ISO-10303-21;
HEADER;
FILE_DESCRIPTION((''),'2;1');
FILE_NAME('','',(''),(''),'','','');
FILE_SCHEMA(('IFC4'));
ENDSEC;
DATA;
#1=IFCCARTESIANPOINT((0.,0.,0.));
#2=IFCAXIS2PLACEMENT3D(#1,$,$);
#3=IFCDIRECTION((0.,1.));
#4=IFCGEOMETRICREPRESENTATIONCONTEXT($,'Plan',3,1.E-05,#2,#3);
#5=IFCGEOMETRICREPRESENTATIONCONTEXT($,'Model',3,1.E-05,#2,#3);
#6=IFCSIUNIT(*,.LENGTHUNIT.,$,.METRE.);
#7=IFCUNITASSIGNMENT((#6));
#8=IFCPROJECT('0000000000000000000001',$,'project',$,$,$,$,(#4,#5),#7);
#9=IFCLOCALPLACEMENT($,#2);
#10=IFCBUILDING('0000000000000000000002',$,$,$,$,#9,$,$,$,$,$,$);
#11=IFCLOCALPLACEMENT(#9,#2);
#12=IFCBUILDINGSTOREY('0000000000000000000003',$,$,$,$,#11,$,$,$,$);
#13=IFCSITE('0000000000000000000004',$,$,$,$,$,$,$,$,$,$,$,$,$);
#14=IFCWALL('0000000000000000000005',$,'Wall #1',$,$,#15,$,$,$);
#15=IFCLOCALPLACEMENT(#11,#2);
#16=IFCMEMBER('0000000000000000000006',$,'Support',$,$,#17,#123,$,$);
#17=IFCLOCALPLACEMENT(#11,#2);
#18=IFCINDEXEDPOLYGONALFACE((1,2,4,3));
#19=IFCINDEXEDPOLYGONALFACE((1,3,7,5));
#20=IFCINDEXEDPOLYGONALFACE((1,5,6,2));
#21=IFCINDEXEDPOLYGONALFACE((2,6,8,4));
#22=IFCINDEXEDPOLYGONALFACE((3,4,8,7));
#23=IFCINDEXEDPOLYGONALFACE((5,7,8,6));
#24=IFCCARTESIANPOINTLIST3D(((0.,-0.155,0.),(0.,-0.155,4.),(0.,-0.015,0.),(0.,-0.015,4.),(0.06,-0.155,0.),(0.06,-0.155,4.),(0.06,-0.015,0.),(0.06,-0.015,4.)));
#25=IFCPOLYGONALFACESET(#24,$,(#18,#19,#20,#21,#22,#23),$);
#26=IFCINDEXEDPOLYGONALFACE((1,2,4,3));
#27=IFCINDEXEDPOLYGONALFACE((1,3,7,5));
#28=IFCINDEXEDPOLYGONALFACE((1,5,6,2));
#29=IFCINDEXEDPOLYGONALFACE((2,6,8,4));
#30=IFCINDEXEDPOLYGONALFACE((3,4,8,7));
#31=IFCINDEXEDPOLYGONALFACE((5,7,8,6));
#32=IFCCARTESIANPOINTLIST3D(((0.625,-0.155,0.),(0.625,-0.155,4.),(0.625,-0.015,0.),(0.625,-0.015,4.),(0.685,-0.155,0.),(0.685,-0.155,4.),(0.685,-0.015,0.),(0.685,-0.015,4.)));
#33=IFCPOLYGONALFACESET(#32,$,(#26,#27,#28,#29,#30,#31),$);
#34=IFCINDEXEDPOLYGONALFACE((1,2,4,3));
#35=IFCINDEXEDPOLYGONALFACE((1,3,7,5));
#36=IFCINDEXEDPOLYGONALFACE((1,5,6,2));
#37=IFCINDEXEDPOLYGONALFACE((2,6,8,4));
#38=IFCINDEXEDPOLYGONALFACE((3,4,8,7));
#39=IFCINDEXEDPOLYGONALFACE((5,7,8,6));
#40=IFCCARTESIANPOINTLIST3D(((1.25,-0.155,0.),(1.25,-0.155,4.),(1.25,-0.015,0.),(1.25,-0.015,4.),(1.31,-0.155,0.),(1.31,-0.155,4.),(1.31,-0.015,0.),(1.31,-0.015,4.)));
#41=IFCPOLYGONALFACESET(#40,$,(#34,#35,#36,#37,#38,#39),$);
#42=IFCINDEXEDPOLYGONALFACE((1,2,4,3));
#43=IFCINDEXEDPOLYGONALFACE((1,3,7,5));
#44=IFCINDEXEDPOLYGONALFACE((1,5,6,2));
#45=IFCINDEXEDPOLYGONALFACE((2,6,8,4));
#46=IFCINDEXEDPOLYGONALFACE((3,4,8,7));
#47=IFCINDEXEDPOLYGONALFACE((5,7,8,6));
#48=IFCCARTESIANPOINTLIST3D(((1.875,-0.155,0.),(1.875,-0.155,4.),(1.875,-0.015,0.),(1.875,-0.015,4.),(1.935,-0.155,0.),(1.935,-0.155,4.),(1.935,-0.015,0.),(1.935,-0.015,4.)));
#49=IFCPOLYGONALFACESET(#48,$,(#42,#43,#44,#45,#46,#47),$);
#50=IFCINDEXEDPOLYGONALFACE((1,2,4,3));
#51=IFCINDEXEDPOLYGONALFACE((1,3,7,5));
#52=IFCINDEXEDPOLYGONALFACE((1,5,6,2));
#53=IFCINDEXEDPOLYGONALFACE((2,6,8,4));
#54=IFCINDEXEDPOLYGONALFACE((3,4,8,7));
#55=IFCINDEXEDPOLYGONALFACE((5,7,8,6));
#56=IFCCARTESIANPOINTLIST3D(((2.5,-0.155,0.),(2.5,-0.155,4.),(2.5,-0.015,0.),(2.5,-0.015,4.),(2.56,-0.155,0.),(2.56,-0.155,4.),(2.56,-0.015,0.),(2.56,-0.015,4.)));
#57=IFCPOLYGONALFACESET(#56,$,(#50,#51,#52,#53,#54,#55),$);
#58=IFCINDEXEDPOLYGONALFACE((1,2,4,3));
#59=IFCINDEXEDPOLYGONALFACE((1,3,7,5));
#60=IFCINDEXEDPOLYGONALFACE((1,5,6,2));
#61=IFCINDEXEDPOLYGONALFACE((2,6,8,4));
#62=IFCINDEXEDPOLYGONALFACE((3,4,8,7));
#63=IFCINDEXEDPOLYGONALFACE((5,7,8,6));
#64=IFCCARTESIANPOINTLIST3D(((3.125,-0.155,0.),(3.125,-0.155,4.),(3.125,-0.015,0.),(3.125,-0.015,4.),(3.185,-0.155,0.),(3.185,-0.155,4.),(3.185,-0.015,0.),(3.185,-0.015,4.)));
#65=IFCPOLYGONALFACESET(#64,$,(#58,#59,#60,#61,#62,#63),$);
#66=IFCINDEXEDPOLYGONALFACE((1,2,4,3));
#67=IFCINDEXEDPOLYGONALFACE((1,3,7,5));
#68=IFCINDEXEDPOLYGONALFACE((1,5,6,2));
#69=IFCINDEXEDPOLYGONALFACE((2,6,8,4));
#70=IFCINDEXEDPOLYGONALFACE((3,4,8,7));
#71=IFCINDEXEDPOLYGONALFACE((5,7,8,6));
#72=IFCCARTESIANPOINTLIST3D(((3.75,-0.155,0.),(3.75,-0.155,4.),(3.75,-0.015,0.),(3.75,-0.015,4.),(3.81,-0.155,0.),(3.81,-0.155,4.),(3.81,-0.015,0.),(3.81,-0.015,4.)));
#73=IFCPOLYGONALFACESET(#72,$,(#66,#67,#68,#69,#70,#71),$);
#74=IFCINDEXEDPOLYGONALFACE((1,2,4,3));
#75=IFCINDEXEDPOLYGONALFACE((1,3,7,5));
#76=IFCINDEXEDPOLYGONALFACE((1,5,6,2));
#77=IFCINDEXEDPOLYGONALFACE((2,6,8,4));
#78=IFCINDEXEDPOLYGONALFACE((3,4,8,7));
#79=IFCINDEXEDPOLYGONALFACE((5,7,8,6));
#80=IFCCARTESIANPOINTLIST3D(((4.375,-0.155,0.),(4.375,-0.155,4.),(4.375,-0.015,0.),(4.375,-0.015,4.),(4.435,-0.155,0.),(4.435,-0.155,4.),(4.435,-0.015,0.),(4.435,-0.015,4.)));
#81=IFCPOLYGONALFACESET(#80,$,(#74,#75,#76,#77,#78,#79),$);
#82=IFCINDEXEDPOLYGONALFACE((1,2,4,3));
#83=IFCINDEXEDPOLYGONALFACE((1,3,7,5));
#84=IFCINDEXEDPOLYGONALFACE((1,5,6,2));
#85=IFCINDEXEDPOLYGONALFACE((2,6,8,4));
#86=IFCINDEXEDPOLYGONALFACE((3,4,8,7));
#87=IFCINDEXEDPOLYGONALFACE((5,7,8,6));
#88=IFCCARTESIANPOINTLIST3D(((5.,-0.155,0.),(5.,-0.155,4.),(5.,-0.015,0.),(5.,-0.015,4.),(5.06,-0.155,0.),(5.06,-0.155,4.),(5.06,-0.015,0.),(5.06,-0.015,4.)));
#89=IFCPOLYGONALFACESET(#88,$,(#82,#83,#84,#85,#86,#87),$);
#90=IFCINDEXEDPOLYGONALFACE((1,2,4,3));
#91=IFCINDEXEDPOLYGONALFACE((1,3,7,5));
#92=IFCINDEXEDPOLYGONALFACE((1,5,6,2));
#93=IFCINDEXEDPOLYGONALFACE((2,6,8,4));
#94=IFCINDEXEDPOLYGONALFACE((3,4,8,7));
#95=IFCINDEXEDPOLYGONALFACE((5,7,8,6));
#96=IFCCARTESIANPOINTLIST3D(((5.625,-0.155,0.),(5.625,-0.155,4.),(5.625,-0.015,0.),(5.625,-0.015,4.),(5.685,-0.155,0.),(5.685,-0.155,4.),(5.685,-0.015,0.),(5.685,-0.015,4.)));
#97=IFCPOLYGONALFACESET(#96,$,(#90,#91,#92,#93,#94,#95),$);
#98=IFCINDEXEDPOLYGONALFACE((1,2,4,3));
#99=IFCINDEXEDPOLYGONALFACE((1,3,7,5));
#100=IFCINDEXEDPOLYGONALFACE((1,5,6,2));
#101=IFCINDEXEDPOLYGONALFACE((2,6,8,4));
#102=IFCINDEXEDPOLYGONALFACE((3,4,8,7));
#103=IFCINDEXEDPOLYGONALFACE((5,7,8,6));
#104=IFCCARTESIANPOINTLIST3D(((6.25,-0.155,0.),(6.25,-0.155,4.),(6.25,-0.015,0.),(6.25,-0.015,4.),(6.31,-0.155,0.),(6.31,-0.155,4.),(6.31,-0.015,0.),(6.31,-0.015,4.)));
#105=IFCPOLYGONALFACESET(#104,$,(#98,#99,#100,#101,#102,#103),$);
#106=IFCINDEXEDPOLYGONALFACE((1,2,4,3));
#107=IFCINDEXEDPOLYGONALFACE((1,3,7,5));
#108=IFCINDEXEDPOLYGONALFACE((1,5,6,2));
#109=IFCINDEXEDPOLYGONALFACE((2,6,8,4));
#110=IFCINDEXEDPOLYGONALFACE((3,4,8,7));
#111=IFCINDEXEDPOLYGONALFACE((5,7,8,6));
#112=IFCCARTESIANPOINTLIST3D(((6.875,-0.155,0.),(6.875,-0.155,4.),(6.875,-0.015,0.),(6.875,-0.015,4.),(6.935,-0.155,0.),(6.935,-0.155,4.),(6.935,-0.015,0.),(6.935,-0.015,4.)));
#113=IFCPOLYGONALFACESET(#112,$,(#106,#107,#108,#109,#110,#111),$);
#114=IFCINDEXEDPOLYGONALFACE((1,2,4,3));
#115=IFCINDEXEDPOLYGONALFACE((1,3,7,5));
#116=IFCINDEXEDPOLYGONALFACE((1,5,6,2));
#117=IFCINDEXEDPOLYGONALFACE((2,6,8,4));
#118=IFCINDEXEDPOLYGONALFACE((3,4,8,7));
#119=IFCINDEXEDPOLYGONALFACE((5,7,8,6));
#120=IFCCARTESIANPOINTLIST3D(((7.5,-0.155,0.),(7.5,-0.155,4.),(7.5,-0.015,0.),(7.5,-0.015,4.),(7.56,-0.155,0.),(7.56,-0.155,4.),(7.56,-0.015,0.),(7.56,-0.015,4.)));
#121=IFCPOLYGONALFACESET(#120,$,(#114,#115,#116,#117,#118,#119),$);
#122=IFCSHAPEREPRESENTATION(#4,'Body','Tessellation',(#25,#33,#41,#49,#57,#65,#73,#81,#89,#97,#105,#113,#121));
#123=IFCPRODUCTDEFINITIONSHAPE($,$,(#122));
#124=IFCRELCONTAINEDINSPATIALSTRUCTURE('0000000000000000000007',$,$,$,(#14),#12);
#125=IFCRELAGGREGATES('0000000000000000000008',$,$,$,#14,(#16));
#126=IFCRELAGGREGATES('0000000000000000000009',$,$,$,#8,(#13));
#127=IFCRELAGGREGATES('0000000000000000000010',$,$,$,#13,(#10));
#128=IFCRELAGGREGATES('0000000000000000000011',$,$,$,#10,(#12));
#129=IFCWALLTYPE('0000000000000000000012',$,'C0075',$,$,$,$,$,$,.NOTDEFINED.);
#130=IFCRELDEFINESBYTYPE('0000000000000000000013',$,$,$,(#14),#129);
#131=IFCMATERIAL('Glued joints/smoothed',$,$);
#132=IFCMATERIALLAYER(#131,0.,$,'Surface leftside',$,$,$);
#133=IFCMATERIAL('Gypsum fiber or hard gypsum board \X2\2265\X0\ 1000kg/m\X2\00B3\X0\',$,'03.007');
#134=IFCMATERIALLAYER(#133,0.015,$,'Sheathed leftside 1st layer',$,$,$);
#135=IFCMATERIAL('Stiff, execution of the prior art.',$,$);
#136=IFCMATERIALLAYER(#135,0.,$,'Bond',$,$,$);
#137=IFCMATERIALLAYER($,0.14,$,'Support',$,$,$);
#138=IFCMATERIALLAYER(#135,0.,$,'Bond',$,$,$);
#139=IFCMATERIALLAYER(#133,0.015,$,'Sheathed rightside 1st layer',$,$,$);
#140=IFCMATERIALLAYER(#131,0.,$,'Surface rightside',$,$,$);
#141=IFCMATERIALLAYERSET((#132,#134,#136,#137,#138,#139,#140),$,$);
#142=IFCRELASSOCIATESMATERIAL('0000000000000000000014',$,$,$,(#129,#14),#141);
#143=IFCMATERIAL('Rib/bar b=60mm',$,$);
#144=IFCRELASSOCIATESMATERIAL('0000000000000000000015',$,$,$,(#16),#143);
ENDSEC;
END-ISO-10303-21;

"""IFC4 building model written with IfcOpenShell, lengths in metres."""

from ifc_helpers import new_model, si_unit, direction, frame, frame_2d, origin, place, context, project, spatial, rectangle, extrude, material, layer, layer_set, type_object, element, aggregate, save


model = new_model("IFC4")

# Units and contexts
plan_context = context("Plan", 3, precision=1e-05, world=origin(), true_north=direction((0.0, 1.0)))
model_context = context("Model", 3, precision=1e-05, world=origin(), true_north=direction((0.0, 1.0)))
ifc_project = project(units=[si_unit("LENGTHUNIT", "METRE")], contexts=[plan_context, model_context])

# Site, building, storey
site = spatial("IfcSite", under=ifc_project)
building_placement = place(None, origin())
building = spatial("IfcBuilding", under=site, at=building_placement)
storey_placement = place(building_placement, origin())
storey = spatial("IfcBuildingStorey", under=building, at=storey_placement)

# Wall, member
ifc_material_1 = material(Name="Glued joints/smoothed")
ifc_layer_1 = layer(ifc_material_1, 0.0, Name="Surface leftside")
ifc_material_2 = material(Name="Gypsum fiber or hard gypsum board ≥ 1000kg/m³", Category="03.007")
ifc_layer_2 = layer(ifc_material_2, 0.015, Name="Sheathed leftside 1st layer")
ifc_material_3 = material(Name="Stiff, execution of the prior art.")
ifc_layer_3 = layer(ifc_material_3, 0.0, Name="Bond")
ifc_layer_4 = layer(None, 0.14, Name="Support")
ifc_layer_5 = layer(ifc_material_3, 0.0, Name="Bond")
ifc_layer_6 = layer(ifc_material_2, 0.015, Name="Sheathed rightside 1st layer")
ifc_layer_7 = layer(ifc_material_1, 0.0, Name="Surface rightside")
ifc_layer_set = layer_set([ifc_layer_1, ifc_layer_2, ifc_layer_3, ifc_layer_4, ifc_layer_5, ifc_layer_6, ifc_layer_7])
wall_type = type_object("IfcWallType", Name="C0075", PredefinedType="NOTDEFINED", material=ifc_layer_set)
wall_placement = place(None, frame((0.0, 0.0, 0.0), z_axis=(0.0, -1.0, 0.0), x_axis=(1.0, 0.0, 0.0)))
wall = element("IfcWall", 1, at=wall_placement, inside=storey, type_object=wall_type, material=ifc_layer_set, Name="Wall #1")
ifc_material_4 = material(Name="Rib/bar b=60mm")
member_1_placement = place(wall_placement, origin())
member_1 = element("IfcMember", 2, at=member_1_placement, material=ifc_material_4, Name="Support", context=plan_context, shape_type="SweptSolid", body=[
    extrude(rectangle(XDim=0.06, YDim=0.14, at=frame_2d((0.03, 0.07), x_axis=(1.0, 0.0))), frame((0.0, 4.0, 0.015), z_axis=(0.0, -1.0, 0.0), x_axis=(1.0, 0.0, 0.0)), (0.0, 0.0, 1.0), 4.0),
    extrude(rectangle(XDim=0.06, YDim=0.14, at=frame_2d((0.03, 0.07), x_axis=(1.0, 0.0))), frame((0.625, 4.0, 0.015), z_axis=(0.0, -1.0, 0.0), x_axis=(1.0, 0.0, 0.0)), (0.0, 0.0, 1.0), 4.0),
    extrude(rectangle(XDim=0.06, YDim=0.14, at=frame_2d((0.03, 0.07), x_axis=(1.0, 0.0))), frame((1.25, 4.0, 0.015), z_axis=(0.0, -1.0, 0.0), x_axis=(1.0, 0.0, 0.0)), (0.0, 0.0, 1.0), 4.0),
    extrude(rectangle(XDim=0.06, YDim=0.14, at=frame_2d((0.03, 0.07), x_axis=(1.0, 0.0))), frame((1.875, 4.0, 0.015), z_axis=(0.0, -1.0, 0.0), x_axis=(1.0, 0.0, 0.0)), (0.0, 0.0, 1.0), 4.0),
    extrude(rectangle(XDim=0.06, YDim=0.14, at=frame_2d((0.03, 0.07), x_axis=(1.0, 0.0))), frame((2.5, 4.0, 0.015), z_axis=(0.0, -1.0, 0.0), x_axis=(1.0, 0.0, 0.0)), (0.0, 0.0, 1.0), 4.0),
    extrude(rectangle(XDim=0.06, YDim=0.14, at=frame_2d((0.03, 0.07), x_axis=(1.0, 0.0))), frame((3.125, 4.0, 0.015), z_axis=(0.0, -1.0, 0.0), x_axis=(1.0, 0.0, 0.0)), (0.0, 0.0, 1.0), 4.0),
    extrude(rectangle(XDim=0.06, YDim=0.14, at=frame_2d((0.03, 0.07), x_axis=(1.0, 0.0))), frame((3.75, 4.0, 0.015), z_axis=(0.0, -1.0, 0.0), x_axis=(1.0, 0.0, 0.0)), (0.0, 0.0, 1.0), 4.0),
    extrude(rectangle(XDim=0.06, YDim=0.14, at=frame_2d((0.03, 0.07), x_axis=(1.0, 0.0))), frame((4.375, 4.0, 0.015), z_axis=(0.0, -1.0, 0.0), x_axis=(1.0, 0.0, 0.0)), (0.0, 0.0, 1.0), 4.0),
    extrude(rectangle(XDim=0.06, YDim=0.14, at=frame_2d((0.03, 0.07), x_axis=(1.0, 0.0))), frame((5.0, 4.0, 0.015), z_axis=(0.0, -1.0, 0.0), x_axis=(1.0, 0.0, 0.0)), (0.0, 0.0, 1.0), 4.0),
    extrude(rectangle(XDim=0.06, YDim=0.14, at=frame_2d((0.03, 0.07), x_axis=(1.0, 0.0))), frame((5.625, 4.0, 0.015), z_axis=(0.0, -1.0, 0.0), x_axis=(1.0, 0.0, 0.0)), (0.0, 0.0, 1.0), 4.0),
    extrude(rectangle(XDim=0.06, YDim=0.14, at=frame_2d((0.03, 0.07), x_axis=(1.0, 0.0))), frame((6.25, 4.0, 0.015), z_axis=(0.0, -1.0, 0.0), x_axis=(1.0, 0.0, 0.0)), (0.0, 0.0, 1.0), 4.0),
    extrude(rectangle(XDim=0.06, YDim=0.14, at=frame_2d((0.03, 0.07), x_axis=(1.0, 0.0))), frame((6.875, 4.0, 0.015), z_axis=(0.0, -1.0, 0.0), x_axis=(1.0, 0.0, 0.0)), (0.0, 0.0, 1.0), 4.0),
    extrude(rectangle(XDim=0.06, YDim=0.14, at=frame_2d((0.03, 0.07), x_axis=(1.0, 0.0))), frame((7.5, 4.0, 0.015), z_axis=(0.0, -1.0, 0.0), x_axis=(1.0, 0.0, 0.0)), (0.0, 0.0, 1.0), 4.0),
])
aggregate(wall, [member_1])

save(model, "model.ifc")
